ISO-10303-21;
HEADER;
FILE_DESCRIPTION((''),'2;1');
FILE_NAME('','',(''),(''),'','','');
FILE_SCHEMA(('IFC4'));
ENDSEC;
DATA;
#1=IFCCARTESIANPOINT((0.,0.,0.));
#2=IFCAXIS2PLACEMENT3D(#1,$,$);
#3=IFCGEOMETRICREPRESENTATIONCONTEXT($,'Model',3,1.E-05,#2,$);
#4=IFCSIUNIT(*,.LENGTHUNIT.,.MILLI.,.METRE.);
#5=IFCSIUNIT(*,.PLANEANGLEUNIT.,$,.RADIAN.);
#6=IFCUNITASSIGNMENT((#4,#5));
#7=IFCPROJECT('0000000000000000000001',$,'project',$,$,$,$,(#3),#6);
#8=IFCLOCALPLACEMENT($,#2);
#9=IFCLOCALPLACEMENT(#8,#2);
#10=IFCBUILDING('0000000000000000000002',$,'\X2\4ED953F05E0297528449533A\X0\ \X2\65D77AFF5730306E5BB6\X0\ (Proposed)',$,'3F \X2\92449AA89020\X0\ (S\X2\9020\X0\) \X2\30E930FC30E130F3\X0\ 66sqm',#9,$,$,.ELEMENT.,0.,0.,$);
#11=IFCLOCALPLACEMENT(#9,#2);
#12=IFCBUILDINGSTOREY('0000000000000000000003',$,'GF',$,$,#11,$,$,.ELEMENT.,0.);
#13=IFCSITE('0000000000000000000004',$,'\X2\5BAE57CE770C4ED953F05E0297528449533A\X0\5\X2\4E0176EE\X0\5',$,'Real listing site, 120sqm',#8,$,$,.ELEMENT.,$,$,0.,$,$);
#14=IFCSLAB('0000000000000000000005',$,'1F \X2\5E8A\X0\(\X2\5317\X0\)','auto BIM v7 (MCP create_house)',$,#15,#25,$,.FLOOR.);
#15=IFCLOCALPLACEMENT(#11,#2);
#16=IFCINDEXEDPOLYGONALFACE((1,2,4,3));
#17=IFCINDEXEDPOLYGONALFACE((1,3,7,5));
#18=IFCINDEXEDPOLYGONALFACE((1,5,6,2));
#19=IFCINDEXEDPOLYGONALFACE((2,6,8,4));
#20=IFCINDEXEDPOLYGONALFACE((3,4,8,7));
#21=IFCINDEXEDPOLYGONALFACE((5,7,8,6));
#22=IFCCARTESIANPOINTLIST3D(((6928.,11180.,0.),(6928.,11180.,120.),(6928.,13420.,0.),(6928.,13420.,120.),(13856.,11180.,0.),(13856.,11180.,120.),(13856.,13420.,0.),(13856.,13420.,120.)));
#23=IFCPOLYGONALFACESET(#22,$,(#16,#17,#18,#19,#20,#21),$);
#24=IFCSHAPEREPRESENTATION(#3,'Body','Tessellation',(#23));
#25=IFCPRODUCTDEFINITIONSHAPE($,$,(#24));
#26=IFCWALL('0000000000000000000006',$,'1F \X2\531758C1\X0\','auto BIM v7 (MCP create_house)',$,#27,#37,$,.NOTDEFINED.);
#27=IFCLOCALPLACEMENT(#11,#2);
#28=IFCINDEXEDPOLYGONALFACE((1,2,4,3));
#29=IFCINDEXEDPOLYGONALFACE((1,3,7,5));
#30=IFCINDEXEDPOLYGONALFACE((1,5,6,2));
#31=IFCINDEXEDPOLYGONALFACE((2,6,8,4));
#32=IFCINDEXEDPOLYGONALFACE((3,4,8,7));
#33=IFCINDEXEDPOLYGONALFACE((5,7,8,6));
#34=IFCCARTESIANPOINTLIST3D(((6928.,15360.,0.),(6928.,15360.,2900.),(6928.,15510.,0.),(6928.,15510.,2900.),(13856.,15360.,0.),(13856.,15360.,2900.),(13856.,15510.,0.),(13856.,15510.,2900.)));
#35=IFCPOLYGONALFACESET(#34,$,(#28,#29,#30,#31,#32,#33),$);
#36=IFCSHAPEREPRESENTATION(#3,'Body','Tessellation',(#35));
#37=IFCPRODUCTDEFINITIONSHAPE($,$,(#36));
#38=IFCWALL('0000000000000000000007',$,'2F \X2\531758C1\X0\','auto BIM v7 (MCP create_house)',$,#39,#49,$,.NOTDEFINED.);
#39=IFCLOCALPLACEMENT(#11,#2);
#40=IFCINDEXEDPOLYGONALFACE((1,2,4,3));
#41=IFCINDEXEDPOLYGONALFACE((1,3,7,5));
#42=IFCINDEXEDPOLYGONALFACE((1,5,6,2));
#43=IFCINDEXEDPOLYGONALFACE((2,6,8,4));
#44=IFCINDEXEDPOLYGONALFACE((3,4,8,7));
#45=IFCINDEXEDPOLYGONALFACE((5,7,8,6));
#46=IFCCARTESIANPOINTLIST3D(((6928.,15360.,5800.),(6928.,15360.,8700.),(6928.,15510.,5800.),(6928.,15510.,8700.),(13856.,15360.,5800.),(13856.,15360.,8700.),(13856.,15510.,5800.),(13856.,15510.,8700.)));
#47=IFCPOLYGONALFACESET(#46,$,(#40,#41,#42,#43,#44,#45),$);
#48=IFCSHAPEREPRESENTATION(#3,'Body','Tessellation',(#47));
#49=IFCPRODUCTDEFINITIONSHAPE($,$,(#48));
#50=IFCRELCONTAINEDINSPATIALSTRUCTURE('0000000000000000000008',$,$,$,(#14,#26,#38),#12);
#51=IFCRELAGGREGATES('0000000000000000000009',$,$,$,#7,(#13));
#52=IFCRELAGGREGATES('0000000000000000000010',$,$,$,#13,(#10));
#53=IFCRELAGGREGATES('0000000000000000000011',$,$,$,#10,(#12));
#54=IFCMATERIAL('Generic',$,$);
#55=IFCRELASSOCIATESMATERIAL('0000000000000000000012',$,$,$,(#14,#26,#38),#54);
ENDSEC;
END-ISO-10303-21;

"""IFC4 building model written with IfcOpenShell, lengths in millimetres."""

from ifc_helpers import new_model, si_unit, frame, frame_2d, origin, place, context, project, spatial, rectangle, extrude, material, element, save


model = new_model("IFC4")

# Units and contexts
model_context = context("Model", 3, precision=1e-05, world=origin())
ifc_project = project(units=[si_unit("LENGTHUNIT", "METRE", prefix="MILLI"), si_unit("PLANEANGLEUNIT", "RADIAN")], contexts=[model_context])

# Site, building, storey
site_placement = place(None, origin())
site = spatial("IfcSite", under=ifc_project, at=site_placement, Name="宮城県仙台市青葉区5丁目5", ObjectType="Real listing site, 120sqm", CompositionType="ELEMENT", RefElevation=0.0)
building_placement = place(site_placement, origin())
building = spatial("IfcBuilding", under=site, at=building_placement, Name="仙台市青葉区 旗竿地の家 (Proposed)", ObjectType="3F 鉄骨造 (S造) ラーメン 66sqm", CompositionType="ELEMENT", ElevationOfRefHeight=0.0, ElevationOfTerrain=0.0)
storey_placement = place(building_placement, origin())
storey = spatial("IfcBuildingStorey", under=building, at=storey_placement, Name="GF", CompositionType="ELEMENT", Elevation=0.0)

# Slab
ifc_material = material(Name="Generic")
slab_1_placement = place(storey_placement, frame((3464.0, 5590.0, 0.0)))
element("IfcSlab", 1, at=slab_1_placement, inside=storey, material=ifc_material, Name="1F 床(北)", Description="auto BIM v7 (MCP create_house)", PredefinedType="FLOOR", context=model_context, shape_type="SweptSolid", body=[
    extrude(rectangle(XDim=6928.0, YDim=2240.0, at=frame_2d((3464.0, 1120.0))), frame((3464.0, 5590.0, 0.0)), (0.0, 0.0, 1.0), 120.0),
])

# Wall
wall_1_placement = place(storey_placement, frame((3464.0, 7680.0, 0.0)))
element("IfcWall", 2, at=wall_1_placement, inside=storey, material=ifc_material, Name="1F 北壁", Description="auto BIM v7 (MCP create_house)", PredefinedType="NOTDEFINED", context=model_context, shape_type="SweptSolid", body=[
    extrude(rectangle(XDim=6928.0, YDim=150.0, at=frame_2d((3464.0, 75.0))), frame((3464.0, 7680.0, 0.0)), (0.0, 0.0, 1.0), 2900.0),
])

# Wall
wall_2_placement = place(storey_placement, frame((3464.0, 7680.0, 2900.0)))
element("IfcWall", 3, at=wall_2_placement, inside=storey, material=ifc_material, Name="2F 北壁", Description="auto BIM v7 (MCP create_house)", PredefinedType="NOTDEFINED", context=model_context, shape_type="SweptSolid", body=[
    extrude(rectangle(XDim=6928.0, YDim=150.0, at=frame_2d((3464.0, 75.0))), frame((3464.0, 7680.0, 2900.0)), (0.0, 0.0, 1.0), 2900.0),
])

save(model, "model.ifc")
